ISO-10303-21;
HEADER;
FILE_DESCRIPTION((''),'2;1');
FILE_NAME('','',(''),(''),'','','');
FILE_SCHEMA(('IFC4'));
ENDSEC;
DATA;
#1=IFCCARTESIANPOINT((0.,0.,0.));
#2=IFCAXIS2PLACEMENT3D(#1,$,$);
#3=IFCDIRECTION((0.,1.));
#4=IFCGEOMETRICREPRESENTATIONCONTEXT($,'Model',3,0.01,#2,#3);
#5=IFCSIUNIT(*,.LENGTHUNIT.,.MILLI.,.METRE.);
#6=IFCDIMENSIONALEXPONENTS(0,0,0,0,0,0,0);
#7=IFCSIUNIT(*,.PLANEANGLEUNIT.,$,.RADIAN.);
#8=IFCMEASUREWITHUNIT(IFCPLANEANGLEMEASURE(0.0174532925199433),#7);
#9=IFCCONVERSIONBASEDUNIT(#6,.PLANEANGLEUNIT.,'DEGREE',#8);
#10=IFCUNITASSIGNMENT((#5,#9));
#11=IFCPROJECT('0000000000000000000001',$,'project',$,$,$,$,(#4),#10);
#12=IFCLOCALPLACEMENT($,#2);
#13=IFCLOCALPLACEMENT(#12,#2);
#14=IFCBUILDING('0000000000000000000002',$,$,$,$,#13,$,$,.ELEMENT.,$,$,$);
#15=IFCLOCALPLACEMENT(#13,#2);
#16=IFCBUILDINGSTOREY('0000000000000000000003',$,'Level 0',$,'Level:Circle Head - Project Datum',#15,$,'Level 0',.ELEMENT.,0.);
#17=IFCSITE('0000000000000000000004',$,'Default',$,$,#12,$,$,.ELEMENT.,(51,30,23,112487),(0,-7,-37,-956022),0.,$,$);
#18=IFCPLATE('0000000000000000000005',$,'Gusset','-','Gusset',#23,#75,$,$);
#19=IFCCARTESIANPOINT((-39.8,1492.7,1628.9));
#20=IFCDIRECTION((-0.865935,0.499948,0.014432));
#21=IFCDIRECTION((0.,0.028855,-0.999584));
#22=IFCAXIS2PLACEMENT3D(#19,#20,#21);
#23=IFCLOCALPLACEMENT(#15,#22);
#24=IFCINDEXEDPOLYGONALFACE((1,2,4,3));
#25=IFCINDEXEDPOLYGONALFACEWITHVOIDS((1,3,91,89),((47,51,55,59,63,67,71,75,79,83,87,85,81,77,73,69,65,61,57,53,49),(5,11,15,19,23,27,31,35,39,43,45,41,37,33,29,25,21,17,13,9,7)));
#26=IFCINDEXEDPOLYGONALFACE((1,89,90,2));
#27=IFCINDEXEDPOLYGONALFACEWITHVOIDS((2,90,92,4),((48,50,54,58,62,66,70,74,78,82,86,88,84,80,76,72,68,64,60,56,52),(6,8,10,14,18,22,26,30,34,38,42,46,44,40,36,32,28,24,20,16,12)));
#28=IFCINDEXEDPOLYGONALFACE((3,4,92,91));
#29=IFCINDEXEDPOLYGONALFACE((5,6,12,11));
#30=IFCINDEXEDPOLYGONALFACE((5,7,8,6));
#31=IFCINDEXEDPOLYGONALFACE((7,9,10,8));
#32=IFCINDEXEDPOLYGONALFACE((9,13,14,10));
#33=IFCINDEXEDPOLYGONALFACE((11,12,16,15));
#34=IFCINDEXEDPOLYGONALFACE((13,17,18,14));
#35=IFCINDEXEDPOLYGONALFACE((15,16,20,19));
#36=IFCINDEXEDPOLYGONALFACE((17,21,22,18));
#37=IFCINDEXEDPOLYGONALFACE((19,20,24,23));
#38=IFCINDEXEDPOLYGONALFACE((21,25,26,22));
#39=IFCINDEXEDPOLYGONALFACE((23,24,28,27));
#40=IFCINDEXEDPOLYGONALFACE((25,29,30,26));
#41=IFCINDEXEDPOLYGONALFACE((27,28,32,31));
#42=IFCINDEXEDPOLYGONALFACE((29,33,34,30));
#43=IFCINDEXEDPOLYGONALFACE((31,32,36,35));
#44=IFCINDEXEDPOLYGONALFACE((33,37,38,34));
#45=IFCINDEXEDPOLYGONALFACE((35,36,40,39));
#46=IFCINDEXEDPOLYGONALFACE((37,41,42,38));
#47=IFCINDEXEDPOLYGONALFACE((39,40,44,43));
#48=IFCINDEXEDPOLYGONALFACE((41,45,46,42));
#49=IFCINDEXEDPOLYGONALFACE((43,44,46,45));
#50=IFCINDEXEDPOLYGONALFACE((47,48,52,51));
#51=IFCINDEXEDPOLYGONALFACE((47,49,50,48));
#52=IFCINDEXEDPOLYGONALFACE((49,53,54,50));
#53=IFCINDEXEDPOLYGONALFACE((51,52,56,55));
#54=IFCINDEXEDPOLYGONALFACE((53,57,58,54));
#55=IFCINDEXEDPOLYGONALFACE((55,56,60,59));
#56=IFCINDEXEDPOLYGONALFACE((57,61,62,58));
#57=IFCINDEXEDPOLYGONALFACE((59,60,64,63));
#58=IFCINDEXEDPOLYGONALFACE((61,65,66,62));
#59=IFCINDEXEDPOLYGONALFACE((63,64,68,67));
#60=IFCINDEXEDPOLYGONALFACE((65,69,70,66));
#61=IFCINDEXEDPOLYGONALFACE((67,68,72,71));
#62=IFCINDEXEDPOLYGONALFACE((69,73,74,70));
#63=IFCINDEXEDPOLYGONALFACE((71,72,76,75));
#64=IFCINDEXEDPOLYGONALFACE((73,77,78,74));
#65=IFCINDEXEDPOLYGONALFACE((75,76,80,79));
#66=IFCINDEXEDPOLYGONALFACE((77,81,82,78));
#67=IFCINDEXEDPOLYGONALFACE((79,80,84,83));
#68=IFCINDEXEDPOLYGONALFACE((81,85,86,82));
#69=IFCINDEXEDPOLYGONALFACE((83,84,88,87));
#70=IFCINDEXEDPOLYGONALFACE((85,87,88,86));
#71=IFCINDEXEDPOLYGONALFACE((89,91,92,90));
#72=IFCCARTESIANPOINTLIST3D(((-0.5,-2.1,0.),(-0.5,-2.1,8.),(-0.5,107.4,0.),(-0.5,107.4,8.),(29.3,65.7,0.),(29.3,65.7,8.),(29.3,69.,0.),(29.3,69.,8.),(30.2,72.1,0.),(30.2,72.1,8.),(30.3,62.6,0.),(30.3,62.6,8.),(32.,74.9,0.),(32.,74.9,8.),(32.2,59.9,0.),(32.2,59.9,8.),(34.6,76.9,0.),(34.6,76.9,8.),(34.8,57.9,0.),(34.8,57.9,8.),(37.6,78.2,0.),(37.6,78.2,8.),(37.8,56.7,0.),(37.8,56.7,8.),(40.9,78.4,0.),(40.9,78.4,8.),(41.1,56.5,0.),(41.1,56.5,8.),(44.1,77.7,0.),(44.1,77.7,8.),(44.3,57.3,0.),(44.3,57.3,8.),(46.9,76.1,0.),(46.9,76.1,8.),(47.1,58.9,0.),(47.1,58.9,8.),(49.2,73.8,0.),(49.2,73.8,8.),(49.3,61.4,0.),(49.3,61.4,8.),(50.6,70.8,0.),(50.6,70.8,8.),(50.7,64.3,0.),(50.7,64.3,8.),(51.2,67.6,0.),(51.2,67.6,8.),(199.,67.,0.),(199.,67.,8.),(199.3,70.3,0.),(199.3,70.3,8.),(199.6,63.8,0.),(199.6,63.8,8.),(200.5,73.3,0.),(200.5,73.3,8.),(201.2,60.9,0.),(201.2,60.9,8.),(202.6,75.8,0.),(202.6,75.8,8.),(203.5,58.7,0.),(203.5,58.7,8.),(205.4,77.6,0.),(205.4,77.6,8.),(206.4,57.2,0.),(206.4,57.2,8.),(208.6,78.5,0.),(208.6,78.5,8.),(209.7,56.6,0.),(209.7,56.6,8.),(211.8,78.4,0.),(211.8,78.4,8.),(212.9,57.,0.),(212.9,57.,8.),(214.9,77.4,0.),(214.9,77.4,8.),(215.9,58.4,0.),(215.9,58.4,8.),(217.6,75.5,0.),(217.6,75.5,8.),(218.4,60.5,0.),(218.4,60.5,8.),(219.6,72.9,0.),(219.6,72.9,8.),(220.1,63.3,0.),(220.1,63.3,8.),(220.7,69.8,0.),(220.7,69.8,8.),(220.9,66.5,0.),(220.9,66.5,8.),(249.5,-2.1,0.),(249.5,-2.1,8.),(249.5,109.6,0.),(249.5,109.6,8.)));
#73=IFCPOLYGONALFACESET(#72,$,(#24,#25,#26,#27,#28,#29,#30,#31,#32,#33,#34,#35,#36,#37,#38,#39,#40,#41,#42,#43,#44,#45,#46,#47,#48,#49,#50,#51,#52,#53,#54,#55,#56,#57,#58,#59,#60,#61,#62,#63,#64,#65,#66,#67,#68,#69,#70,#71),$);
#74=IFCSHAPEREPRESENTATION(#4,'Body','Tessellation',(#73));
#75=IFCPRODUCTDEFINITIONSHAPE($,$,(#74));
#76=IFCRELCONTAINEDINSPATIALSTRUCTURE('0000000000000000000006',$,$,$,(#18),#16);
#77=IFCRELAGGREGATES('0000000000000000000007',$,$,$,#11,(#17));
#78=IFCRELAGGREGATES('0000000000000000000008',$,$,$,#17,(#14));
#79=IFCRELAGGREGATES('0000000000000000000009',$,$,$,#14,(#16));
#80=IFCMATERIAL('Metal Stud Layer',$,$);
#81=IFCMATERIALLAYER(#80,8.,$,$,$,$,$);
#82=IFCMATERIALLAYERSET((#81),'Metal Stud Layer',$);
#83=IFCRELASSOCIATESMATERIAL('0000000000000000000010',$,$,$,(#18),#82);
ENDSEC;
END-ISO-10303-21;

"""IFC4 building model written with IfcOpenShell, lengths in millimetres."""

from ifc_helpers import new_model, entity, si_unit, converted_unit, direction, frame, origin, origin_with_axes, origin_2d_with_axis, place, context, project, spatial, polyline, circle, outline, extrude, material, layer, layer_set, element, save


model = new_model("IFC4")

# Units and contexts
model_context = context("Model", 3, precision=0.01, world=origin(), true_north=direction((0.0, 1.0)))
ifc_project = project(units=[si_unit("LENGTHUNIT", "METRE", prefix="MILLI"), converted_unit("PLANEANGLEUNIT", "DEGREE", entity("IfcPlaneAngleMeasure", 0.0174532925199433), si_unit("PLANEANGLEUNIT", "RADIAN"), dimensions=[0, 0, 0, 0, 0, 0, 0])], contexts=[model_context])

# Site, building, storey
site_placement = place(None, origin())
site = spatial("IfcSite", under=ifc_project, at=site_placement, Name="Default", CompositionType="ELEMENT", RefLatitude=(51, 30, 23, 112487), RefLongitude=(0, -7, -37, -956022), RefElevation=0.0)
building_placement = place(site_placement, origin())
building = spatial("IfcBuilding", under=site, at=building_placement, CompositionType="ELEMENT")
storey_placement = place(building_placement, origin())
storey = spatial("IfcBuildingStorey", under=building, at=storey_placement, Name="Level 0", ObjectType="Level:Circle Head - Project Datum", LongName="Level 0", CompositionType="ELEMENT", Elevation=0.0)

# Plate, openings
ifc_material_1 = material(Name="Metal Stud Layer")
ifc_layer_1 = layer(ifc_material_1, 8.0)
ifc_layer_set_1 = layer_set([ifc_layer_1], Name="Metal Stud Layer")
plate_1_placement = place(storey_placement, frame((-39.8, 1492.7, 1628.9), z_axis=(-0.865935, 0.499948, 0.014432), x_axis=(0.0, 0.028855, -0.999584)))
plate_1 = element("IfcPlate", 1, at=plate_1_placement, inside=storey, material=ifc_layer_set_1, Name="Gusset", Description="-", ObjectType="Gusset", context=model_context, shape_type="SweptSolid", body=[
    extrude(outline(polyline([(-0.5, -2.1), (249.5, -2.1), (249.5, 109.6), (-0.5, 107.4), (-0.5, -2.1)])), origin_with_axes(), (0.0, 0.0, 1.0), 8.0),
])
opening_1_placement = place(plate_1_placement, frame((40.2, 67.5, 8.5), z_axis=(0.0, 0.0, -1.0), x_axis=(-0.509076, 0.860722, 0.0)))
element("IfcOpeningElement", 2, at=opening_1_placement, cuts=plate_1, ObjectType="Opening", context=model_context, shape_type="SweptSolid", body=[
    extrude(circle(Radius=11.0, at=origin_2d_with_axis()), origin(), (0.0, 0.0, 1.0), 9.0),
])
opening_2_placement = place(plate_1_placement, frame((209.9, 67.6, 8.5), z_axis=(0.0, 0.0, -1.0), x_axis=(0.455098, 0.890441, 0.0)))
element("IfcOpeningElement", 3, at=opening_2_placement, cuts=plate_1, ObjectType="Opening", context=model_context, shape_type="SweptSolid", body=[
    extrude(circle(Radius=11.0, at=origin_2d_with_axis()), origin(), (0.0, 0.0, 1.0), 9.0),
])

save(model, "model.ifc")
